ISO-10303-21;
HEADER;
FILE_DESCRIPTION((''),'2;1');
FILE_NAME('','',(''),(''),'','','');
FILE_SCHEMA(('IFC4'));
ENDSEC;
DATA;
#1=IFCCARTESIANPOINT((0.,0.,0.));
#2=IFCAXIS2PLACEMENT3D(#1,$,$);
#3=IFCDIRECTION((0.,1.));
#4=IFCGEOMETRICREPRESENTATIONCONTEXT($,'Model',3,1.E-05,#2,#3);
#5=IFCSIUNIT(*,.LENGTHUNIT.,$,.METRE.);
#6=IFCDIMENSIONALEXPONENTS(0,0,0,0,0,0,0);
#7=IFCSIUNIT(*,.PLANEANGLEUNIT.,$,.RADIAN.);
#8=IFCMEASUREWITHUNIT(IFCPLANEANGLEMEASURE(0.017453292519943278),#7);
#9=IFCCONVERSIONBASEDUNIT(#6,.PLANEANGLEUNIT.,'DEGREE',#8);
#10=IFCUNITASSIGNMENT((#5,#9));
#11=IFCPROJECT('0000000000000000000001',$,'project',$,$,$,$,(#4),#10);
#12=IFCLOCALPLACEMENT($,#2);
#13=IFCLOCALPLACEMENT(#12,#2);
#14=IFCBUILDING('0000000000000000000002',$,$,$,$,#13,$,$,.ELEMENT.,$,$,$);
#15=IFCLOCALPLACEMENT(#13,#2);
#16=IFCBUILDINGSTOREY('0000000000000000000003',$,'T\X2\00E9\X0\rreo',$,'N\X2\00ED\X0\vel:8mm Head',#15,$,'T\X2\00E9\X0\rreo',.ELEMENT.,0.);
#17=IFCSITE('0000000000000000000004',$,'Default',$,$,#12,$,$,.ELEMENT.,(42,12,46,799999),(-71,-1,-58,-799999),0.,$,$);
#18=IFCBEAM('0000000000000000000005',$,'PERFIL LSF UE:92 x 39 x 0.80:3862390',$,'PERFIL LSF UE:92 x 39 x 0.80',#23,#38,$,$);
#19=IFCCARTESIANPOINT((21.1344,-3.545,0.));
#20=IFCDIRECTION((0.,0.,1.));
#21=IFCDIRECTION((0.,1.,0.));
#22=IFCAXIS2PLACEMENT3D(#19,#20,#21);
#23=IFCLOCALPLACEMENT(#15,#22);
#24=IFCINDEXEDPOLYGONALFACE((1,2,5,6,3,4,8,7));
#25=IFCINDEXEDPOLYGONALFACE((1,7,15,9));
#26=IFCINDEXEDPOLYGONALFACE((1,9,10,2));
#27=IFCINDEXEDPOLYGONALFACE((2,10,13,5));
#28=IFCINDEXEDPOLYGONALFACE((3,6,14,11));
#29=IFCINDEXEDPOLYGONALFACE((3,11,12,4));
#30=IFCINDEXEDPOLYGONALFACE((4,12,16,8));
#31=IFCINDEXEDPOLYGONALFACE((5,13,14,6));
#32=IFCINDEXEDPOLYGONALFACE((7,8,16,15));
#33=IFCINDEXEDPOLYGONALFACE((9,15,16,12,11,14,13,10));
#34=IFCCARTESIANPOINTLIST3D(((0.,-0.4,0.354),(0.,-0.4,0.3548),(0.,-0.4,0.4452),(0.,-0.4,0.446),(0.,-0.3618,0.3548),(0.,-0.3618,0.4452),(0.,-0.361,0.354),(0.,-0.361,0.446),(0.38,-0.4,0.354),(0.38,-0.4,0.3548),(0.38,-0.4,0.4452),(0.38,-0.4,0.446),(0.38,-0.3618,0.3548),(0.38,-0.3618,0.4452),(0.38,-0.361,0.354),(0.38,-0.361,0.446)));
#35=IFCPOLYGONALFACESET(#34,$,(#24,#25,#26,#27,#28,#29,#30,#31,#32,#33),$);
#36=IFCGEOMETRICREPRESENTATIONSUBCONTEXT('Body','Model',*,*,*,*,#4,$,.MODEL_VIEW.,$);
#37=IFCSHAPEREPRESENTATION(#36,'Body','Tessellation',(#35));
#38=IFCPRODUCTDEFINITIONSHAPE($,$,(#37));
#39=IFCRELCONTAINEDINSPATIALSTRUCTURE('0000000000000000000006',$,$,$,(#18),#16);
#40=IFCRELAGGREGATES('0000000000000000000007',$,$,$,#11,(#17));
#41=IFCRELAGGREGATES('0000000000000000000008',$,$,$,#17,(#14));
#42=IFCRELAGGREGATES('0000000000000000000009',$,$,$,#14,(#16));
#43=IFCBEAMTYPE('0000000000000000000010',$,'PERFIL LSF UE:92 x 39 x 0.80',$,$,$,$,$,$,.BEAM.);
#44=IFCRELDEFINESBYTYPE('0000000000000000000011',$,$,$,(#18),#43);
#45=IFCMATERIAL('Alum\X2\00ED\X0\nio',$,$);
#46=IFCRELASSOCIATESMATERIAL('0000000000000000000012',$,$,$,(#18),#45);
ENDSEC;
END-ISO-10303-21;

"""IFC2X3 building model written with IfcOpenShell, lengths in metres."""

from ifc_helpers import new_model, entity, si_unit, converted_unit, direction, frame, origin, place, context, subcontext, project, spatial, polyline, outline, extrude, material, type_object, element, save


model = new_model("IFC2X3")

# Units and contexts
model_context = context("Model", 3, precision=1e-05, world=origin(), true_north=direction((0.0, 1.0)))
body_context = subcontext(model_context, "Body", "Model", "MODEL_VIEW")
ifc_project = project(units=[si_unit("LENGTHUNIT", "METRE"), converted_unit("PLANEANGLEUNIT", "DEGREE", entity("IfcPlaneAngleMeasure", 0.017453292519943278), si_unit("PLANEANGLEUNIT", "RADIAN"), dimensions=[0, 0, 0, 0, 0, 0, 0])], contexts=[model_context])

# Site, building, storey
site_placement = place(None, origin())
site = spatial("IfcSite", under=ifc_project, at=site_placement, Name="Default", CompositionType="ELEMENT", RefLatitude=(42, 12, 46, 799999), RefLongitude=(-71, -1, -58, -799999), RefElevation=0.0)
building_placement = place(site_placement, origin())
building = spatial("IfcBuilding", under=site, at=building_placement, CompositionType="ELEMENT")
storey_placement = place(building_placement, origin())
storey = spatial("IfcBuildingStorey", under=building, at=storey_placement, Name="Térreo", ObjectType="Nível:8mm Head", LongName="Térreo", CompositionType="ELEMENT", Elevation=0.0)

# Beam
ifc_material_1 = material(Name="Alumínio")
beam_type = type_object("IfcBeamType", Name="PERFIL LSF UE:92 x 39 x 0.80", PredefinedType="BEAM")
beam_1_placement = place(storey_placement, frame((21.1344, -3.545, 0.0), z_axis=(0.0, 0.0, 1.0), x_axis=(0.0, 1.0, 0.0)))
element("IfcBeam", 1, at=beam_1_placement, inside=storey, type_object=beam_type, material=ifc_material_1, Name="PERFIL LSF UE:92 x 39 x 0.80:3862390", ObjectType="PERFIL LSF UE:92 x 39 x 0.80", context=body_context, shape_type="SweptSolid", body=[
    extrude(outline(polyline([(-0.046, -0.0193), (-0.0452, -0.0193), (-0.0452, 0.0189), (0.0452, 0.0189), (0.0452, -0.0193), (0.046, -0.0193), (0.046, 0.0197), (-0.046, 0.0197), (-0.046, -0.0193)])), frame((0.0, -0.3807, 0.4), z_axis=(1.0, 0.0, 0.0), x_axis=(0.0, 0.0, -1.0)), (0.0, 0.0, 1.0), 0.38),
])

save(model, "model.ifc")
